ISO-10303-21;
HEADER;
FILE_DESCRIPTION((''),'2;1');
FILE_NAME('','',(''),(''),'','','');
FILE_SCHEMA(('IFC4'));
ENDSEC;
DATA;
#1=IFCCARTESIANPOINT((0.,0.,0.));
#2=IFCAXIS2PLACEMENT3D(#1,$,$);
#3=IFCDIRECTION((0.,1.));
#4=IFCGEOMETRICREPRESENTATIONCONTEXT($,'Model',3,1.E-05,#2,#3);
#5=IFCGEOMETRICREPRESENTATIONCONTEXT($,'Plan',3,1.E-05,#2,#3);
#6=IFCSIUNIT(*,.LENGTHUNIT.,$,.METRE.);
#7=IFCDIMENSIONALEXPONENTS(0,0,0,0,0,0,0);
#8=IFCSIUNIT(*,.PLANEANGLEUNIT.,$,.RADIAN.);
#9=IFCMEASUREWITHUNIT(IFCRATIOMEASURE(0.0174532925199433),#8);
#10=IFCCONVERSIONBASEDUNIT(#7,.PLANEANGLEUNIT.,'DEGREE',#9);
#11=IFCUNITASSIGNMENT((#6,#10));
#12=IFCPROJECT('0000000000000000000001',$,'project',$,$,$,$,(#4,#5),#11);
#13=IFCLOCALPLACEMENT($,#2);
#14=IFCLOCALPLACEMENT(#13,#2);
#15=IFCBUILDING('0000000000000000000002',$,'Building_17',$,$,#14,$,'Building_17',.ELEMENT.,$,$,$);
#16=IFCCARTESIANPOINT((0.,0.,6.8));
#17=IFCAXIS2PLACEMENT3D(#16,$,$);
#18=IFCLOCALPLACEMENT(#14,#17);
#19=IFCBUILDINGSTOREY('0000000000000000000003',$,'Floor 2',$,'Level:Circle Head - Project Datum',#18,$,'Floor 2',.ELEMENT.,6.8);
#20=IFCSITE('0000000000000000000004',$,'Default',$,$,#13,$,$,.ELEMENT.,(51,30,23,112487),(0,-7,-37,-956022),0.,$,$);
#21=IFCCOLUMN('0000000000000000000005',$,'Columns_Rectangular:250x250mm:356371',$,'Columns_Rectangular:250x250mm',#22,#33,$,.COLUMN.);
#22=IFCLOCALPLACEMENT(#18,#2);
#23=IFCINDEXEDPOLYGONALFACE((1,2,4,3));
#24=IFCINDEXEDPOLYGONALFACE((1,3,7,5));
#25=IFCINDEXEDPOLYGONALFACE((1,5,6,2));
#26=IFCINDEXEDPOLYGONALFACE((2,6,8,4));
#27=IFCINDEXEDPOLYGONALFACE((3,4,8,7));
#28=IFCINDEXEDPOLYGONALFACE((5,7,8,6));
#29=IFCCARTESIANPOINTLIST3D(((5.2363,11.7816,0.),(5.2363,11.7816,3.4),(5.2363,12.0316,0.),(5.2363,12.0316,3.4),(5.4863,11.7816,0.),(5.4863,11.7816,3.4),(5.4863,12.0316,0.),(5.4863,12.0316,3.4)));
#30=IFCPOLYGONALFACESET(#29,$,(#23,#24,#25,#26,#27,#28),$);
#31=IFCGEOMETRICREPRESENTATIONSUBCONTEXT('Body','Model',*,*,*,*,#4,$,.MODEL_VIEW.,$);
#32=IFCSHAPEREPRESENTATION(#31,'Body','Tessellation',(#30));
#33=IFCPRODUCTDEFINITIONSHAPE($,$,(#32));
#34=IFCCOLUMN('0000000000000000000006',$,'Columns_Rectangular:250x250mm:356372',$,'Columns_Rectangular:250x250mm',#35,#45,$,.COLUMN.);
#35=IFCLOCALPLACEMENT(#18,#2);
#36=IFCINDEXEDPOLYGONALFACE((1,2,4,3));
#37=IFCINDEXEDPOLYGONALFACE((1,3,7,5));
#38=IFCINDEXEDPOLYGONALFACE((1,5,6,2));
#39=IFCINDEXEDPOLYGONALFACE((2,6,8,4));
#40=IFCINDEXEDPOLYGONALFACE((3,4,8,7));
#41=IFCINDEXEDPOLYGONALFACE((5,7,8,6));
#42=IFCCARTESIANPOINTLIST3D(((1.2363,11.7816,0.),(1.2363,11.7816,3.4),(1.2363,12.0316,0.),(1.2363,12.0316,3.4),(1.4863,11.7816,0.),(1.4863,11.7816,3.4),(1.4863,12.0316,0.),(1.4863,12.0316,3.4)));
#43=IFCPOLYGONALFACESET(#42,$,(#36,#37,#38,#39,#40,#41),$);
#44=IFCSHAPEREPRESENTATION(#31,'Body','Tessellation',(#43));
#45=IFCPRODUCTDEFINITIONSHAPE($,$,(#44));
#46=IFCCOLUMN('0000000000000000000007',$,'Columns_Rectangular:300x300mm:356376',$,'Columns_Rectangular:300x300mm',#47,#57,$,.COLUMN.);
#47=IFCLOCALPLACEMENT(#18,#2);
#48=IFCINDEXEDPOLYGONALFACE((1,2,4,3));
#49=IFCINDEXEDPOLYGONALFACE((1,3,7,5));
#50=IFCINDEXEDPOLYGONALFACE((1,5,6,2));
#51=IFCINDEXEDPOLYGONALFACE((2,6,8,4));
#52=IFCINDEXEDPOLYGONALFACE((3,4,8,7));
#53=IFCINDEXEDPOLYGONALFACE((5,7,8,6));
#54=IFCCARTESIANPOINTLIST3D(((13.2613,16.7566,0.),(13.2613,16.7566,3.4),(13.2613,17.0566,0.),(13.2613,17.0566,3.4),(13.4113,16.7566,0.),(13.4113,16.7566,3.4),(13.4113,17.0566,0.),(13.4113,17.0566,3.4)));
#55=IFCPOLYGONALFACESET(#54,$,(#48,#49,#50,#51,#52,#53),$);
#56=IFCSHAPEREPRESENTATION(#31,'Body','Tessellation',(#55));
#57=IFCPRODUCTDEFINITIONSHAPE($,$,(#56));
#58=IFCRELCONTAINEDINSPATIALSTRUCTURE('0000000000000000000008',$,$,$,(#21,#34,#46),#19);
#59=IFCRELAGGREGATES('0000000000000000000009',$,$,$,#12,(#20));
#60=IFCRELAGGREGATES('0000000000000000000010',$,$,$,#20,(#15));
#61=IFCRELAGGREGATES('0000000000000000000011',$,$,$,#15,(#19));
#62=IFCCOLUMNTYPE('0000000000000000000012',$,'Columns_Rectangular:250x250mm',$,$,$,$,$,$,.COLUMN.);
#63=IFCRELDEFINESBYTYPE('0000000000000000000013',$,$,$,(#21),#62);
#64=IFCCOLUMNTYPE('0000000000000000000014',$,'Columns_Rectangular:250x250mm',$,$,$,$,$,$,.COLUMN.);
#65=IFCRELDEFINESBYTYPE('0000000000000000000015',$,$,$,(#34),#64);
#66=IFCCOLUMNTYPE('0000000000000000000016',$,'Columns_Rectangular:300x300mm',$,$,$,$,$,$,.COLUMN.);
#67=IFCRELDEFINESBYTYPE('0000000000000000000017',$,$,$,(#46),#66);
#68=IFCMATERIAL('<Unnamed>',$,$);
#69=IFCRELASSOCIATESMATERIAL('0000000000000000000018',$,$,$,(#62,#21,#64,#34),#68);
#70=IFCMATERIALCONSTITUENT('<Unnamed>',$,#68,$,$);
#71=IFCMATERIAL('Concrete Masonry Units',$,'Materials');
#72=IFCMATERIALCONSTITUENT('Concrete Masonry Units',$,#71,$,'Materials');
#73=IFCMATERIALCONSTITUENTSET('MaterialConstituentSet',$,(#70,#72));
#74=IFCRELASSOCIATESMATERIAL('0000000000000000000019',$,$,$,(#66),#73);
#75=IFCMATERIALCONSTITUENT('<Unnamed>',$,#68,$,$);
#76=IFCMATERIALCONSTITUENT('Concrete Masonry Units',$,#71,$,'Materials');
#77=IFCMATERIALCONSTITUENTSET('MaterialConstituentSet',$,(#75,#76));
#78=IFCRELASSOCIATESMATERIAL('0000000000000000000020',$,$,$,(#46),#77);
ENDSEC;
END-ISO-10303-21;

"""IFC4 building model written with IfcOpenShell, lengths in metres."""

from ifc_helpers import new_model, entity, si_unit, converted_unit, direction, frame, origin, place, context, subcontext, project, spatial, indexed_curve, outline, extrude, source, transform, mapped, material, constituent, constituent_set, type_object, type_shapes, element, save


model = new_model("IFC4")

# Units and contexts
model_context = context("Model", 3, precision=1e-05, world=origin(), true_north=direction((0.0, 1.0)))
plan_context = context("Plan", 3, precision=1e-05, world=origin(), true_north=direction((0.0, 1.0)))
body_context = subcontext(model_context, "Body", "Model", "MODEL_VIEW")
ifc_project = project(units=[si_unit("LENGTHUNIT", "METRE"), converted_unit("PLANEANGLEUNIT", "DEGREE", entity("IfcRatioMeasure", 0.0174532925199433), si_unit("PLANEANGLEUNIT", "RADIAN"), dimensions=[0, 0, 0, 0, 0, 0, 0])], contexts=[model_context, plan_context])

# Site, building, storey
site_placement = place(None, origin())
site = spatial("IfcSite", under=ifc_project, at=site_placement, Name="Default", CompositionType="ELEMENT", RefLatitude=(51, 30, 23, 112487), RefLongitude=(0, -7, -37, -956022), RefElevation=0.0)
building_placement = place(site_placement, origin())
building = spatial("IfcBuilding", under=site, at=building_placement, Name="Building_17", LongName="Building_17", CompositionType="ELEMENT")
storey_placement = place(building_placement, frame((0.0, 0.0, 6.8)))
storey = spatial("IfcBuildingStorey", under=building, at=storey_placement, Name="Floor 2", ObjectType="Level:Circle Head - Project Datum", LongName="Floor 2", CompositionType="ELEMENT", Elevation=6.8)

# Columns
ifc_material_1 = material(Name="<Unnamed>")
ifc_material_2 = material(Name="Concrete Masonry Units", Category="Materials")
column_type_1 = type_object("IfcColumnType", Name="Columns_Rectangular:250x250mm", PredefinedType="COLUMN", material=ifc_material_1)
shared_shape_1 = source(origin(), body_context, "Body", "SweptSolid", [
    extrude(outline(indexed_curve([(-0.125, -0.125), (0.125, -0.125), (0.125, 0.125), (-0.125, 0.125), (-0.125, -0.125)], self_intersect=False)), frame((5.3613, 11.9066, 6.8), z_axis=(0.0, 0.0, 1.0), x_axis=(0.0, -1.0, 0.0)), (0.0, 0.0, 1.0), 3.4),
])
type_shapes(column_type_1, [shared_shape_1])
column_1_placement = place(storey_placement, frame((0.0, 0.0, -6.8)))
element("IfcColumn", 1, at=column_1_placement, inside=storey, type_object=column_type_1, material=ifc_material_1, Name="Columns_Rectangular:250x250mm:356371", ObjectType="Columns_Rectangular:250x250mm", PredefinedType="COLUMN", context=body_context, shape_type="MappedRepresentation", body=[
    mapped(shared_shape_1, transform((0.0, 0.0, 0.0), scale=1.0)),
])
column_type_2 = type_object("IfcColumnType", Name="Columns_Rectangular:250x250mm", PredefinedType="COLUMN", material=ifc_material_1)
shared_shape_2 = source(origin(), body_context, "Body", "SweptSolid", [
    extrude(outline(indexed_curve([(-0.125, -0.125), (0.125, -0.125), (0.125, 0.125), (-0.125, 0.125), (-0.125, -0.125)], self_intersect=False)), frame((1.3613, 11.9066, 6.8), z_axis=(0.0, 0.0, 1.0), x_axis=(0.0, -1.0, 0.0)), (0.0, 0.0, 1.0), 3.4),
])
type_shapes(column_type_2, [shared_shape_2])
column_2_placement = place(storey_placement, frame((0.0, 0.0, -6.8)))
element("IfcColumn", 2, at=column_2_placement, inside=storey, type_object=column_type_2, material=ifc_material_1, Name="Columns_Rectangular:250x250mm:356372", ObjectType="Columns_Rectangular:250x250mm", PredefinedType="COLUMN", context=body_context, shape_type="MappedRepresentation", body=[
    mapped(shared_shape_2, transform((0.0, 0.0, 0.0), scale=1.0)),
])
ifc_constituent_1 = constituent(ifc_material_1, Name="<Unnamed>")
ifc_constituent_2 = constituent(ifc_material_2, Name="Concrete Masonry Units", Category="Materials")
ifc_constituent_set_1 = constituent_set(constituents=[ifc_constituent_1, ifc_constituent_2], Name="MaterialConstituentSet")
ifc_constituent_3 = constituent(ifc_material_1, Name="<Unnamed>")
ifc_constituent_4 = constituent(ifc_material_2, Name="Concrete Masonry Units", Category="Materials")
ifc_constituent_set_2 = constituent_set(constituents=[ifc_constituent_3, ifc_constituent_4], Name="MaterialConstituentSet")
column_type_3 = type_object("IfcColumnType", Name="Columns_Rectangular:300x300mm", PredefinedType="COLUMN", material=ifc_constituent_set_2)
shared_shape_3 = source(origin(), body_context, "Body", "SweptSolid", [
    extrude(outline(indexed_curve([(-0.15, -0.075), (0.15, -0.075), (0.15, 0.075), (-0.15, 0.075), (-0.15, -0.075)], self_intersect=False)), frame((13.3363, 16.9066, 6.8), z_axis=(0.0, 0.0, 1.0), x_axis=(0.0, -1.0, 0.0)), (0.0, 0.0, 1.0), 3.4),
])
type_shapes(column_type_3, [shared_shape_3])
column_3_placement = place(storey_placement, frame((0.0, 0.0, -6.8)))
element("IfcColumn", 3, at=column_3_placement, inside=storey, type_object=column_type_3, material=ifc_constituent_set_1, Name="Columns_Rectangular:300x300mm:356376", ObjectType="Columns_Rectangular:300x300mm", PredefinedType="COLUMN", context=body_context, shape_type="MappedRepresentation", body=[
    mapped(shared_shape_3, transform((0.0, 0.0, 0.0), scale=1.0)),
])

save(model, "model.ifc")
